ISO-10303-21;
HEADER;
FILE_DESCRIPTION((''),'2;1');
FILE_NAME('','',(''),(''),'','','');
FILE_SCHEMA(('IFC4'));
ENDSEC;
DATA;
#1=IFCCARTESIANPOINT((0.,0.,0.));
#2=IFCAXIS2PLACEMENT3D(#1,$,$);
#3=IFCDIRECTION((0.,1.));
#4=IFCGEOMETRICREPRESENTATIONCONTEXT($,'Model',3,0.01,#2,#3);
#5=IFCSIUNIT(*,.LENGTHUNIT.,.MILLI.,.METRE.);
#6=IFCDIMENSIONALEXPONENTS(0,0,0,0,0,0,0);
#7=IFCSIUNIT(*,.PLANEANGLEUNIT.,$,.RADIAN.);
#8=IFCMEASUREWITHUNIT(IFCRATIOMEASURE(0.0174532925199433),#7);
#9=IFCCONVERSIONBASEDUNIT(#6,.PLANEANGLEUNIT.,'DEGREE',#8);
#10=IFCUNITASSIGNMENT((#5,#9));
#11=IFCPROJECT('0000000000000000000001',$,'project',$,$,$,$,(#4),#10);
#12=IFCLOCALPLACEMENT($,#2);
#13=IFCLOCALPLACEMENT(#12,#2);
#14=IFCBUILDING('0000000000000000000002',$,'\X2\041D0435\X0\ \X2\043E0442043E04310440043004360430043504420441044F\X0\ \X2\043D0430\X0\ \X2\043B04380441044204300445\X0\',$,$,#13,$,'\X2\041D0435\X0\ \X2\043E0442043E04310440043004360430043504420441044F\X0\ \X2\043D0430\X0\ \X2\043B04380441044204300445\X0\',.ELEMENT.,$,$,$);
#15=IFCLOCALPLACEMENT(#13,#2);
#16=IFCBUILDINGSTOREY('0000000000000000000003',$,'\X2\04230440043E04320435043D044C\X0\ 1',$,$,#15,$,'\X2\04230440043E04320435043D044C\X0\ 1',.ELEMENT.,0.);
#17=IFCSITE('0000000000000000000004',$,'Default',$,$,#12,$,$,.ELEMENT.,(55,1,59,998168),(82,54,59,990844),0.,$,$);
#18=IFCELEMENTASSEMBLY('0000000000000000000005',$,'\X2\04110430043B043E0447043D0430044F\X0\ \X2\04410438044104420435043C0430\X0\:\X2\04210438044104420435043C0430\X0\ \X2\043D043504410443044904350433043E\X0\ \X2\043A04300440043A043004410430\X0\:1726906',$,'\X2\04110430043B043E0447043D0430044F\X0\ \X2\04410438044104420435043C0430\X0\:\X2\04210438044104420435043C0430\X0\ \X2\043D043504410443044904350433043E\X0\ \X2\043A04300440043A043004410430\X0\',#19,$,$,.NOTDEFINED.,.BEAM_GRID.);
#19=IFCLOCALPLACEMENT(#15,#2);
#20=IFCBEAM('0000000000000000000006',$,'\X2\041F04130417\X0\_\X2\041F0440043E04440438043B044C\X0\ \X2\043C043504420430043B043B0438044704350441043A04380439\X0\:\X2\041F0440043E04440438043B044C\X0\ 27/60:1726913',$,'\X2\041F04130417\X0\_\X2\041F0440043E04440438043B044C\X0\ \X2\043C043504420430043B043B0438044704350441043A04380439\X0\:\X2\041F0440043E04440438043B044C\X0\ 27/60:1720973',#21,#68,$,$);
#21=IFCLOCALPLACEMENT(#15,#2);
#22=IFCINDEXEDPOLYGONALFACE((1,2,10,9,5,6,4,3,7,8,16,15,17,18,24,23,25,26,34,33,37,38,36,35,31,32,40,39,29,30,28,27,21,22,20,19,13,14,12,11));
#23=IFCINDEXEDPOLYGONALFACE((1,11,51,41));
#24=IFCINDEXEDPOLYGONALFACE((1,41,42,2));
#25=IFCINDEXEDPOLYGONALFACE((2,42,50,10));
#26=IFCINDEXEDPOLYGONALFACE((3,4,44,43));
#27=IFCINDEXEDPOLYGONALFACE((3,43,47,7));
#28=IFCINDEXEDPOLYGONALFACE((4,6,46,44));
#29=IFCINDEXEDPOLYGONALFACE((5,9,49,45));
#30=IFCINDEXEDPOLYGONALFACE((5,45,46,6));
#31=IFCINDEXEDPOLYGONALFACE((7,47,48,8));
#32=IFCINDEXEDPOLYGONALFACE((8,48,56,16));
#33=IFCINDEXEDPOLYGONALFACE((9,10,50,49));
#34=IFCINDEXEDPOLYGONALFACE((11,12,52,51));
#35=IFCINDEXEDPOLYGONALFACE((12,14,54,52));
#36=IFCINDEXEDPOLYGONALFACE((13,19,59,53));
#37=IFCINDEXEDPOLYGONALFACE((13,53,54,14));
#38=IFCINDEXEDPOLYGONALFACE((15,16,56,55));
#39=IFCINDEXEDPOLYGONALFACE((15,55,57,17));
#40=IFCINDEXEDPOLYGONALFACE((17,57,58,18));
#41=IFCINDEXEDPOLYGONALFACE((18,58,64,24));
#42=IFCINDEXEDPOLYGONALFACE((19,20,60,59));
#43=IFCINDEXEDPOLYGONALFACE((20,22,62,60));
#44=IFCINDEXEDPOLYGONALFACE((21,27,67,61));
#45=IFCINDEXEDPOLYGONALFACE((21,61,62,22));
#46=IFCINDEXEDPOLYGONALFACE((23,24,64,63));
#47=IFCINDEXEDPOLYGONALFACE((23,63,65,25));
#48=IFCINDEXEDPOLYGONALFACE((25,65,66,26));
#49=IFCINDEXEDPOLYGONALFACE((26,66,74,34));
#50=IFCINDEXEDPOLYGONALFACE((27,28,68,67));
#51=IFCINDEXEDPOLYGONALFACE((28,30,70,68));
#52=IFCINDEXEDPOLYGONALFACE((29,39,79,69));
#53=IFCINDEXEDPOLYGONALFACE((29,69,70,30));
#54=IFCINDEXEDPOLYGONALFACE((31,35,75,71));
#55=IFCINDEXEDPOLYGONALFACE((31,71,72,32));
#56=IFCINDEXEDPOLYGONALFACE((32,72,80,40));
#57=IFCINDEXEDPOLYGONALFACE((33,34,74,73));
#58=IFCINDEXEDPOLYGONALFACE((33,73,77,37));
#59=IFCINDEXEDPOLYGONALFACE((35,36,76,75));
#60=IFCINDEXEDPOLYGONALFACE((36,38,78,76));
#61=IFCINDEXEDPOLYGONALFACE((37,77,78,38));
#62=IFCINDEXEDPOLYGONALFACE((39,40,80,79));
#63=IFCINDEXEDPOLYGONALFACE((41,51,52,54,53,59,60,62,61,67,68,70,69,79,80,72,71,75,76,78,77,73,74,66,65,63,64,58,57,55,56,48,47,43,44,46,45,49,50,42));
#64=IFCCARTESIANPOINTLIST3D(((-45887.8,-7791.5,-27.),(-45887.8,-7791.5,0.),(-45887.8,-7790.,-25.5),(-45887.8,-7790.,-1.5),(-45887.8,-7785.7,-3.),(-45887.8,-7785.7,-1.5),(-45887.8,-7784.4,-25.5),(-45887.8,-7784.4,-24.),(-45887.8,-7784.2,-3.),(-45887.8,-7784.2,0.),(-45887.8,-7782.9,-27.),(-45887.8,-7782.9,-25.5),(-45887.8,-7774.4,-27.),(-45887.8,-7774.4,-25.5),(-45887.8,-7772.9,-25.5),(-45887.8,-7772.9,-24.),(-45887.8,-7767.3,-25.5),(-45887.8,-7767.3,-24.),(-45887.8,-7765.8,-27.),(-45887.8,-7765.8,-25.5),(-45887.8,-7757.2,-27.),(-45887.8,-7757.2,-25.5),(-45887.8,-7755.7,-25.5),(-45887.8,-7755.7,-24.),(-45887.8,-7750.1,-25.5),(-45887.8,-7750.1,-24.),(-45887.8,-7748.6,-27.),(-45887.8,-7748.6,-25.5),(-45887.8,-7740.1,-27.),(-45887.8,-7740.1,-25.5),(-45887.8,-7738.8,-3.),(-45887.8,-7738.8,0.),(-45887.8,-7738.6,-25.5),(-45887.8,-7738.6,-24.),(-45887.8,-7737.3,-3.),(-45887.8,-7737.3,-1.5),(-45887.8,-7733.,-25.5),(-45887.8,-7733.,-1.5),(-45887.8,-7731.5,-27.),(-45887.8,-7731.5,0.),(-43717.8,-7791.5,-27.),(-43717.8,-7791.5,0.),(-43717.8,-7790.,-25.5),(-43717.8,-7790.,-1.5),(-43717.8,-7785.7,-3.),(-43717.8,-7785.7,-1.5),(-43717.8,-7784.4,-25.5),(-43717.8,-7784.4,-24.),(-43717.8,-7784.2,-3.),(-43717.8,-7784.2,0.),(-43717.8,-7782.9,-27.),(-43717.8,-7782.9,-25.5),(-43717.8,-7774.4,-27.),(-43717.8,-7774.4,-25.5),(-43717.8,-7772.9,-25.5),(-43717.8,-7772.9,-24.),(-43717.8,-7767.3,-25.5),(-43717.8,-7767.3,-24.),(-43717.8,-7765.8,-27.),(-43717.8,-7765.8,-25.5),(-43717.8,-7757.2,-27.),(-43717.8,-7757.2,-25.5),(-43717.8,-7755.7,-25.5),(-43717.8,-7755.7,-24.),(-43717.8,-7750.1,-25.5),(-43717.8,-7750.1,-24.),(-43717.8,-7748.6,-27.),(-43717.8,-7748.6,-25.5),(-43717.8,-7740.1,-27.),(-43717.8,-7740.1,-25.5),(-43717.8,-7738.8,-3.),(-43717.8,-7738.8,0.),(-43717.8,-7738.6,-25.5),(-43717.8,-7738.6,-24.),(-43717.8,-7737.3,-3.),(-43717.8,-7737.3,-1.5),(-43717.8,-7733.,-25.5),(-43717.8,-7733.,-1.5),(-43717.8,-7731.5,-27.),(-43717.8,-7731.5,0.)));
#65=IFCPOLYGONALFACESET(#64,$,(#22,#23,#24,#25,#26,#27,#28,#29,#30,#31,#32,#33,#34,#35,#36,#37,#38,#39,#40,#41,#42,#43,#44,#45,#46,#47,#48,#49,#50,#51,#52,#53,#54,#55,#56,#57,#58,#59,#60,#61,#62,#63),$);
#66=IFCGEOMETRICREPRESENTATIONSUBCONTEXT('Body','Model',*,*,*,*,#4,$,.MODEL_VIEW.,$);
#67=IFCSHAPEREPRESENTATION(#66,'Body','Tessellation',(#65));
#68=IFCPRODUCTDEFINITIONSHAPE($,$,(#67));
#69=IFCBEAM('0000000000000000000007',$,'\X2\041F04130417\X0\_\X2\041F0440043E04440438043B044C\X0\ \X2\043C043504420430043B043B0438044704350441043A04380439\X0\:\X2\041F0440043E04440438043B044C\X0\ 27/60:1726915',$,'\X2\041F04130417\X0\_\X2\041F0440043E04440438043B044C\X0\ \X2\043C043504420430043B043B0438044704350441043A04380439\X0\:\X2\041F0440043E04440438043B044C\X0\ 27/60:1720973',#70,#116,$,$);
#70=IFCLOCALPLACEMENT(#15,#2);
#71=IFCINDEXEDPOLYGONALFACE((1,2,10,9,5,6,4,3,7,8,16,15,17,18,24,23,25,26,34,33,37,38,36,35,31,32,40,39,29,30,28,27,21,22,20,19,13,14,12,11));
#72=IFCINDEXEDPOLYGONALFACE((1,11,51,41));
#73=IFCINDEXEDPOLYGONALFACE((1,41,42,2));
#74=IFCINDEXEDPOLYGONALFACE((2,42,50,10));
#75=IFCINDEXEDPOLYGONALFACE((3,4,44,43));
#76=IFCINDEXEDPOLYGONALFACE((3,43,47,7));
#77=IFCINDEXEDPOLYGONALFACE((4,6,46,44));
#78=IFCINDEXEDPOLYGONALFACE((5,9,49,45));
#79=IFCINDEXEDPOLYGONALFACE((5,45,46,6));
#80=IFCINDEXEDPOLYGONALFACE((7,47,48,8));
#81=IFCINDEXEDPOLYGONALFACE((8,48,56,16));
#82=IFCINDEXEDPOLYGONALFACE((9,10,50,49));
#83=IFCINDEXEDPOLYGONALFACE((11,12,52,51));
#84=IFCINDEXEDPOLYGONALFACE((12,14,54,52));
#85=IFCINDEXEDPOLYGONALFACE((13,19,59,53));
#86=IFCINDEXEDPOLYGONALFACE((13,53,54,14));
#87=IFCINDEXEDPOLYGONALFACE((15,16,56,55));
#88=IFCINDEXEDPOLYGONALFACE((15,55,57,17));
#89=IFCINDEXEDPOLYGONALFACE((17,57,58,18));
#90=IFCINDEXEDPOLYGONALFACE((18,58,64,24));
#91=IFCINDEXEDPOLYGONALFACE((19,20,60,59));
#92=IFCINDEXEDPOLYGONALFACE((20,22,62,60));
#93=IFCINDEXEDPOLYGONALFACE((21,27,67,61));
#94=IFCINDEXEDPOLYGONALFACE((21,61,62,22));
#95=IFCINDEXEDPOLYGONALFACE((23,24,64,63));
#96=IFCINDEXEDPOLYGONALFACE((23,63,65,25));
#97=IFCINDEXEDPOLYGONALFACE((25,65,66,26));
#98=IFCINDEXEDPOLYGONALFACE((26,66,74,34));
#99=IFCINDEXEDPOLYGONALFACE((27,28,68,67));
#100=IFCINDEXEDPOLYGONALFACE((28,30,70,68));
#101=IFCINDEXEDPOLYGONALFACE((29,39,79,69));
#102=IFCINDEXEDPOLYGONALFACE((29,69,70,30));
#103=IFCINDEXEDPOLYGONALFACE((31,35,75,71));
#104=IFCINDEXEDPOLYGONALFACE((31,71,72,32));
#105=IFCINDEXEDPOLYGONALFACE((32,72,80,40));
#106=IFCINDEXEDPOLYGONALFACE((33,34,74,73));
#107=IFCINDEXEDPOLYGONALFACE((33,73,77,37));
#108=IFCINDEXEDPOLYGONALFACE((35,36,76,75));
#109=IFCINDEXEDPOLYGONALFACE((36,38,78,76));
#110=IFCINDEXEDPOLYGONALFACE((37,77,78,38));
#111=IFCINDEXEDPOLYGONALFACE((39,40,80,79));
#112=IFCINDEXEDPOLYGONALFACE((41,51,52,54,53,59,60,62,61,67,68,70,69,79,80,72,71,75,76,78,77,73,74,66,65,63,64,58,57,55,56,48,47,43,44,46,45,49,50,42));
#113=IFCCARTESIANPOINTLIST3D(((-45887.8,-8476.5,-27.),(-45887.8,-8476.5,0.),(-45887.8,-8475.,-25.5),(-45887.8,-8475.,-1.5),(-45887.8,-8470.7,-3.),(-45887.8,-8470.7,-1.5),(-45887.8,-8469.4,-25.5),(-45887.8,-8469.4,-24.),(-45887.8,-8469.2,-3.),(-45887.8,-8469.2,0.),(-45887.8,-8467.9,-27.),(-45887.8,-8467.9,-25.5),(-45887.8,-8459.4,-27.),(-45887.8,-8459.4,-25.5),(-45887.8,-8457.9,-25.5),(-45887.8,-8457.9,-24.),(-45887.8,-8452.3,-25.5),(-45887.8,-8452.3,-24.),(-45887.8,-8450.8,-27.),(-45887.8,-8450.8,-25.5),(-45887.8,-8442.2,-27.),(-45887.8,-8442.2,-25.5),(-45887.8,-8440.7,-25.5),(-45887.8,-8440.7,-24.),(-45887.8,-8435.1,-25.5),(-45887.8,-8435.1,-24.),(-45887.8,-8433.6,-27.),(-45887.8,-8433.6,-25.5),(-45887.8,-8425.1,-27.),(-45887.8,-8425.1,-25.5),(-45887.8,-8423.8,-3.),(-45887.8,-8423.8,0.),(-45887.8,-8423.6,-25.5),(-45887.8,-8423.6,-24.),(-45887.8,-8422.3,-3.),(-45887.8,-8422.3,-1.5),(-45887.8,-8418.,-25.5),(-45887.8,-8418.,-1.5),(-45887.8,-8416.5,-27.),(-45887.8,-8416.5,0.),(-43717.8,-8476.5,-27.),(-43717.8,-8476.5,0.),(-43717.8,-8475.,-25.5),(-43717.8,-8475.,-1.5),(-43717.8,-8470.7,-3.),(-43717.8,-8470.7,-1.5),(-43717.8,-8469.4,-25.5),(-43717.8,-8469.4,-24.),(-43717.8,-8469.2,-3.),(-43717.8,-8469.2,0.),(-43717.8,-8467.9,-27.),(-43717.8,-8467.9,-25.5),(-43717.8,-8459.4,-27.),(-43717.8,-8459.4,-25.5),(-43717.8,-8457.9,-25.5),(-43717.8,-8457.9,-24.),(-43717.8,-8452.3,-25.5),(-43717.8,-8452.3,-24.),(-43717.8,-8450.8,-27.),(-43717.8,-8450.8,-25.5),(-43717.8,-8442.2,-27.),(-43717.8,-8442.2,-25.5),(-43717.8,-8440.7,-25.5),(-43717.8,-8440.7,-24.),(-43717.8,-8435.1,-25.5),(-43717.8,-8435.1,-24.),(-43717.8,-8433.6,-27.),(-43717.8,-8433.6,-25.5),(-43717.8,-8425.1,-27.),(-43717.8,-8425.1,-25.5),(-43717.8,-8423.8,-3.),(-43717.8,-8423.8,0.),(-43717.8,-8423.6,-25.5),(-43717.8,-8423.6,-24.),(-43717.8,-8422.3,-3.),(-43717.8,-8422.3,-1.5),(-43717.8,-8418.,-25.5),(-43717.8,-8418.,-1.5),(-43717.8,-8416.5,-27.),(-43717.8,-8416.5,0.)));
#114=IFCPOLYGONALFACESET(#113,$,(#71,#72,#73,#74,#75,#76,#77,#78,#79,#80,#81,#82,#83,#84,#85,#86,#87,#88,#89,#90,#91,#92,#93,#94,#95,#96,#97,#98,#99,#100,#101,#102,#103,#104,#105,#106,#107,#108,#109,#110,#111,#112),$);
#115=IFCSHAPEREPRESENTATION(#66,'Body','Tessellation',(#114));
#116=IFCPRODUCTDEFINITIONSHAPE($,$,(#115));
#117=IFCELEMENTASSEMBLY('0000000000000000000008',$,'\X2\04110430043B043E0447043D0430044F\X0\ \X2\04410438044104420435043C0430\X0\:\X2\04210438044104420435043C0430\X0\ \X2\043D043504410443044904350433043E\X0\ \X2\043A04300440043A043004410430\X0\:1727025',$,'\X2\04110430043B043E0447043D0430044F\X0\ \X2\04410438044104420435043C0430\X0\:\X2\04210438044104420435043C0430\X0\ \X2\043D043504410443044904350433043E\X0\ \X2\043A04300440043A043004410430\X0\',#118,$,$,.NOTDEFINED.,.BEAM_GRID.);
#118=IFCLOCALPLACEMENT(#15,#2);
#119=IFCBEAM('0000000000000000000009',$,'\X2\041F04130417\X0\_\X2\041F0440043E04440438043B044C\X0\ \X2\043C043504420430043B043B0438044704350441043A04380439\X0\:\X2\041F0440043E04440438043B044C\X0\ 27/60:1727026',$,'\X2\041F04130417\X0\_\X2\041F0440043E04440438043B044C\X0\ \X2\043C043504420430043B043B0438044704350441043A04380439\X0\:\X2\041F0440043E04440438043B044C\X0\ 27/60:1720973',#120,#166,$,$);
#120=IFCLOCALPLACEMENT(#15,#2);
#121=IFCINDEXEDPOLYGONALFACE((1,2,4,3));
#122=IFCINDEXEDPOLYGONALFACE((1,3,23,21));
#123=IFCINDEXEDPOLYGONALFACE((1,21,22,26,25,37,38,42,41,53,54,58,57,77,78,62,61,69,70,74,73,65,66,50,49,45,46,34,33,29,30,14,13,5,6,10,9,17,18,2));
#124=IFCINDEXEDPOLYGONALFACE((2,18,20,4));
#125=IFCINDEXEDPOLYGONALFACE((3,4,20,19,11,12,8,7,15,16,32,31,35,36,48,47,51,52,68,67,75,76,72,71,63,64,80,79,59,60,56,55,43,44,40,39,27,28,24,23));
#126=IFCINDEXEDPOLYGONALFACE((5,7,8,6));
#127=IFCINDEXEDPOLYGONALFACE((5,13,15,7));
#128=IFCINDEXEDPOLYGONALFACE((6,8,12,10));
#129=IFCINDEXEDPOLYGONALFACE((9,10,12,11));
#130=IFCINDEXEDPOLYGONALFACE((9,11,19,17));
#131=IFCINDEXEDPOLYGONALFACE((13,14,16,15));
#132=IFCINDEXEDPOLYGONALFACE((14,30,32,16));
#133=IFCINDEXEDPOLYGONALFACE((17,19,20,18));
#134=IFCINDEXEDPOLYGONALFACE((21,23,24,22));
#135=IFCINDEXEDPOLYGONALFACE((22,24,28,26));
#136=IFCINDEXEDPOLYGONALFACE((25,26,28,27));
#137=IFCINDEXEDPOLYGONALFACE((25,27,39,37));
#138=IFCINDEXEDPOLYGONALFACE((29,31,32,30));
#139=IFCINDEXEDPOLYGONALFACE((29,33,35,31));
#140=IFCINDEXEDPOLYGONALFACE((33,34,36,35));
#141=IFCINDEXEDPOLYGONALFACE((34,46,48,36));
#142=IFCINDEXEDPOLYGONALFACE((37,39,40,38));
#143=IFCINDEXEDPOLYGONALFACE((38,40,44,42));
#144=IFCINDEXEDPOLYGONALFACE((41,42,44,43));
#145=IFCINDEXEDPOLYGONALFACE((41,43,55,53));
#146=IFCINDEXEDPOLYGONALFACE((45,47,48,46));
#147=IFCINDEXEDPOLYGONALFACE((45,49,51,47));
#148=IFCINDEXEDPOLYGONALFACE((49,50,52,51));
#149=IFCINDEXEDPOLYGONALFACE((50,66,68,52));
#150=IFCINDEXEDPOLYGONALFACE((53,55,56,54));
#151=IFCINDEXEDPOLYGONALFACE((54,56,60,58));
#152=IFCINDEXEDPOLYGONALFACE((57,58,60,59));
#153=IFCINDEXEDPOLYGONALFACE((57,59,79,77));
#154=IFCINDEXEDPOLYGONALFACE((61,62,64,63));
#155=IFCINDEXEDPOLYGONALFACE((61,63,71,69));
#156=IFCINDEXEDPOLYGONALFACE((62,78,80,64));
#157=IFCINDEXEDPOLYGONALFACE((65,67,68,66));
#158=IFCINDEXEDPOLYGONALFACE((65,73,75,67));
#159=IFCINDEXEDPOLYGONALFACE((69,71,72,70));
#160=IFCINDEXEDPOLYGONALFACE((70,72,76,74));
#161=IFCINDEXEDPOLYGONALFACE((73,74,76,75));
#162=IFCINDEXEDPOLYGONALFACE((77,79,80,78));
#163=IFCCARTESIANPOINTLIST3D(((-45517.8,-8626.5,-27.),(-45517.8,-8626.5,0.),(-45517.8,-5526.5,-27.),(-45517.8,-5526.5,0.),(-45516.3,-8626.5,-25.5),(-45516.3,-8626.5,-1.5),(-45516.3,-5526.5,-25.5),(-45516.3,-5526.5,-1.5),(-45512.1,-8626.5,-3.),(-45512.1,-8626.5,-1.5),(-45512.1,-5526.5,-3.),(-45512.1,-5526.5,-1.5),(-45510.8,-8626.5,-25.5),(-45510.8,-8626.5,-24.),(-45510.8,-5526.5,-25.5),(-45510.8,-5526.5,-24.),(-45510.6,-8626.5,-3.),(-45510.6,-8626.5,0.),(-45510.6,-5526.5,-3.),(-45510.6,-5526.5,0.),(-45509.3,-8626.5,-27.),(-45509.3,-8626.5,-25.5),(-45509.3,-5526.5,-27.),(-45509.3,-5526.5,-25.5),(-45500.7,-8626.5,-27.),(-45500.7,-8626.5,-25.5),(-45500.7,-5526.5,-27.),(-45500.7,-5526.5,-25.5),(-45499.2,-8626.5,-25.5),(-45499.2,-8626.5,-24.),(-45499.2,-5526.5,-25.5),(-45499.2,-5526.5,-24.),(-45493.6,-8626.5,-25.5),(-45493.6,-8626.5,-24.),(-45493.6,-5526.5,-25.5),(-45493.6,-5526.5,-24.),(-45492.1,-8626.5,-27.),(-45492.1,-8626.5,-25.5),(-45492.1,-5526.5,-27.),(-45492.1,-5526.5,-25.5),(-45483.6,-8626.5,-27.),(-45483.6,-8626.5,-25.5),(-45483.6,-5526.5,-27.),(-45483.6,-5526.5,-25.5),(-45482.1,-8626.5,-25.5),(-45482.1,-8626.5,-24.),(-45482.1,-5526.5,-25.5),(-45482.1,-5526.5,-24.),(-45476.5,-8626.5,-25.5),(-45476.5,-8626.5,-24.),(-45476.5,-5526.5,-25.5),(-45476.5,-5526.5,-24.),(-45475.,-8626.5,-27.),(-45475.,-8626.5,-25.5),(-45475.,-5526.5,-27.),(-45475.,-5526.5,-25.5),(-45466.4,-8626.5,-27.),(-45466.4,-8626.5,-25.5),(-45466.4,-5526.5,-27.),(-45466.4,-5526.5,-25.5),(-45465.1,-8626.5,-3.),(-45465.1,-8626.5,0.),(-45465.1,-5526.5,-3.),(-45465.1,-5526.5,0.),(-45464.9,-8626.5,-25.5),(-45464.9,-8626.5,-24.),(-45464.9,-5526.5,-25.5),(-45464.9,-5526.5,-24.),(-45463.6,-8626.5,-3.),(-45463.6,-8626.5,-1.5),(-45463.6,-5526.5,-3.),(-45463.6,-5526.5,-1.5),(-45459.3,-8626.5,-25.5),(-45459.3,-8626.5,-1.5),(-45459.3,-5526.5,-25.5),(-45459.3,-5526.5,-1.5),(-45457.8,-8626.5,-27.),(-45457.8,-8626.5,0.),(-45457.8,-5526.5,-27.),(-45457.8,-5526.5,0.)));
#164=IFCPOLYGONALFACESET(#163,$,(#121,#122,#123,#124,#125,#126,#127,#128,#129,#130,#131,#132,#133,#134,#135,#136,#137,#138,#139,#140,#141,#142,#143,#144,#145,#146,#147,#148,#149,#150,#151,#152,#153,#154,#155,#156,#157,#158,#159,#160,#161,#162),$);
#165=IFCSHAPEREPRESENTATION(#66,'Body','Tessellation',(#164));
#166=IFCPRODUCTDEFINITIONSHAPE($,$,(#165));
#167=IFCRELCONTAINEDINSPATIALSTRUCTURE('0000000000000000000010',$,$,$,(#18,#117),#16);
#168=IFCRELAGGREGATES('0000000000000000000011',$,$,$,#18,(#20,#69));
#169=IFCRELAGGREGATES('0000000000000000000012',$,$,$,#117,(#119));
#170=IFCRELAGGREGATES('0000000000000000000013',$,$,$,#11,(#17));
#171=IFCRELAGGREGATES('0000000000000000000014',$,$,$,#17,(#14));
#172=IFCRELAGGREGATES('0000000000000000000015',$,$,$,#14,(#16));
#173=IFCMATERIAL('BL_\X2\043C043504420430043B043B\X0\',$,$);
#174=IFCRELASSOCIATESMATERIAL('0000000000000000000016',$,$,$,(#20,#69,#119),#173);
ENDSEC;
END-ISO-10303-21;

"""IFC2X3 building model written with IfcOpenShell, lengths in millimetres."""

from ifc_helpers import new_model, entity, si_unit, converted_unit, direction, frame, origin, place, context, subcontext, project, spatial, polyline, outline, extrude, material, element, aggregate, save


model = new_model("IFC2X3")

# Units and contexts
model_context = context("Model", 3, precision=0.01, world=origin(), true_north=direction((0.0, 1.0)))
body_context = subcontext(model_context, "Body", "Model", "MODEL_VIEW")
ifc_project = project(units=[si_unit("LENGTHUNIT", "METRE", prefix="MILLI"), converted_unit("PLANEANGLEUNIT", "DEGREE", entity("IfcRatioMeasure", 0.0174532925199433), si_unit("PLANEANGLEUNIT", "RADIAN"), dimensions=[0, 0, 0, 0, 0, 0, 0])], contexts=[model_context])

# Site, building, storey
site_placement = place(None, origin())
site = spatial("IfcSite", under=ifc_project, at=site_placement, Name="Default", CompositionType="ELEMENT", RefLatitude=(55, 1, 59, 998168), RefLongitude=(82, 54, 59, 990844), RefElevation=0.0)
building_placement = place(site_placement, origin())
building = spatial("IfcBuilding", under=site, at=building_placement, Name="Не отображается на листах", LongName="Не отображается на листах", CompositionType="ELEMENT")
storey_placement = place(building_placement, frame((0.0, 0.0, 0.0)))
storey = spatial("IfcBuildingStorey", under=building, at=storey_placement, Name="Уровень 1", LongName="Уровень 1", CompositionType="ELEMENT", Elevation=0.0)

# Element assemblies, beams
assembly_1_placement = place(storey_placement, origin())
assembly_1 = element("IfcElementAssembly", 1, at=assembly_1_placement, inside=storey, Name="Балочная система:Система несущего каркаса:1726906", ObjectType="Балочная система:Система несущего каркаса", AssemblyPlace="NOTDEFINED", PredefinedType="BEAM_GRID")
ifc_material_1 = material(Name="BL_металл")
beam_1_placement = place(assembly_1_placement, frame((-45887.8, -7761.5, 0.0)))
beam_1 = element("IfcBeam", 2, at=beam_1_placement, material=ifc_material_1, Name="ПГЗ_Профиль металлический:Профиль 27/60:1726913", ObjectType="ПГЗ_Профиль металлический:Профиль 27/60:1720973", context=body_context, shape_type="SweptSolid", body=[
    extrude(outline(polyline([(-18.4, -30.0), (8.6, -30.0), (8.6, -21.4), (7.1, -21.4), (7.1, -12.9), (8.6, -12.9), (8.6, -4.3), (7.1, -4.3), (7.1, 4.3), (8.6, 4.3), (8.6, 12.9), (7.1, 12.9), (7.1, 21.4), (8.6, 21.4), (8.6, 30.0), (-18.4, 30.0), (-18.4, 22.7), (-15.4, 22.7), (-15.4, 24.2), (-16.9, 24.2), (-16.9, 28.5), (7.1, 28.5), (7.1, 22.9), (5.6, 22.9), (5.6, 11.4), (7.1, 11.4), (7.1, 5.8), (5.6, 5.8), (5.6, -5.8), (7.1, -5.8), (7.1, -11.4), (5.6, -11.4), (5.6, -22.9), (7.1, -22.9), (7.1, -28.5), (-16.9, -28.5), (-16.9, -24.2), (-15.4, -24.2), (-15.4, -22.7), (-18.4, -22.7), (-18.4, -30.0)])), frame((0.0, 0.0, -18.4), z_axis=(1.0, 0.0, 0.0), x_axis=(0.0, 0.0, -1.0)), (0.0, 0.0, 1.0), 2170.0),
])
beam_2_placement = place(assembly_1_placement, frame((-45887.8, -8446.5, 0.0)))
beam_2 = element("IfcBeam", 3, at=beam_2_placement, material=ifc_material_1, Name="ПГЗ_Профиль металлический:Профиль 27/60:1726915", ObjectType="ПГЗ_Профиль металлический:Профиль 27/60:1720973", context=body_context, shape_type="SweptSolid", body=[
    extrude(outline(polyline([(-18.4, -30.0), (8.6, -30.0), (8.6, -21.4), (7.1, -21.4), (7.1, -12.9), (8.6, -12.9), (8.6, -4.3), (7.1, -4.3), (7.1, 4.3), (8.6, 4.3), (8.6, 12.9), (7.1, 12.9), (7.1, 21.4), (8.6, 21.4), (8.6, 30.0), (-18.4, 30.0), (-18.4, 22.7), (-15.4, 22.7), (-15.4, 24.2), (-16.9, 24.2), (-16.9, 28.5), (7.1, 28.5), (7.1, 22.9), (5.6, 22.9), (5.6, 11.4), (7.1, 11.4), (7.1, 5.8), (5.6, 5.8), (5.6, -5.8), (7.1, -5.8), (7.1, -11.4), (5.6, -11.4), (5.6, -22.9), (7.1, -22.9), (7.1, -28.5), (-16.9, -28.5), (-16.9, -24.2), (-15.4, -24.2), (-15.4, -22.7), (-18.4, -22.7), (-18.4, -30.0)])), frame((0.0, 0.0, -18.4), z_axis=(1.0, 0.0, 0.0), x_axis=(0.0, 0.0, -1.0)), (0.0, 0.0, 1.0), 2170.0),
])
aggregate(assembly_1, [beam_1, beam_2])
assembly_2_placement = place(storey_placement, origin())
assembly_2 = element("IfcElementAssembly", 4, at=assembly_2_placement, inside=storey, Name="Балочная система:Система несущего каркаса:1727025", ObjectType="Балочная система:Система несущего каркаса", AssemblyPlace="NOTDEFINED", PredefinedType="BEAM_GRID")
beam_3_placement = place(assembly_2_placement, frame((-45487.8, -8626.5, 0.0), z_axis=(0.0, 0.0, 1.0), x_axis=(0.0, 1.0, 0.0)))
beam_3 = element("IfcBeam", 5, at=beam_3_placement, material=ifc_material_1, Name="ПГЗ_Профиль металлический:Профиль 27/60:1727026", ObjectType="ПГЗ_Профиль металлический:Профиль 27/60:1720973", context=body_context, shape_type="SweptSolid", body=[
    extrude(outline(polyline([(-18.4, -30.0), (8.6, -30.0), (8.6, -21.4), (7.1, -21.4), (7.1, -12.9), (8.6, -12.9), (8.6, -4.3), (7.1, -4.3), (7.1, 4.3), (8.6, 4.3), (8.6, 12.9), (7.1, 12.9), (7.1, 21.4), (8.6, 21.4), (8.6, 30.0), (-18.4, 30.0), (-18.4, 22.7), (-15.4, 22.7), (-15.4, 24.2), (-16.9, 24.2), (-16.9, 28.5), (7.1, 28.5), (7.1, 22.9), (5.6, 22.9), (5.6, 11.4), (7.1, 11.4), (7.1, 5.8), (5.6, 5.8), (5.6, -5.8), (7.1, -5.8), (7.1, -11.4), (5.6, -11.4), (5.6, -22.9), (7.1, -22.9), (7.1, -28.5), (-16.9, -28.5), (-16.9, -24.2), (-15.4, -24.2), (-15.4, -22.7), (-18.4, -22.7), (-18.4, -30.0)])), frame((0.0, 0.0, -18.4), z_axis=(1.0, 0.0, 0.0), x_axis=(0.0, 0.0, -1.0)), (0.0, 0.0, 1.0), 3100.0),
])
aggregate(assembly_2, [beam_3])

save(model, "model.ifc")
